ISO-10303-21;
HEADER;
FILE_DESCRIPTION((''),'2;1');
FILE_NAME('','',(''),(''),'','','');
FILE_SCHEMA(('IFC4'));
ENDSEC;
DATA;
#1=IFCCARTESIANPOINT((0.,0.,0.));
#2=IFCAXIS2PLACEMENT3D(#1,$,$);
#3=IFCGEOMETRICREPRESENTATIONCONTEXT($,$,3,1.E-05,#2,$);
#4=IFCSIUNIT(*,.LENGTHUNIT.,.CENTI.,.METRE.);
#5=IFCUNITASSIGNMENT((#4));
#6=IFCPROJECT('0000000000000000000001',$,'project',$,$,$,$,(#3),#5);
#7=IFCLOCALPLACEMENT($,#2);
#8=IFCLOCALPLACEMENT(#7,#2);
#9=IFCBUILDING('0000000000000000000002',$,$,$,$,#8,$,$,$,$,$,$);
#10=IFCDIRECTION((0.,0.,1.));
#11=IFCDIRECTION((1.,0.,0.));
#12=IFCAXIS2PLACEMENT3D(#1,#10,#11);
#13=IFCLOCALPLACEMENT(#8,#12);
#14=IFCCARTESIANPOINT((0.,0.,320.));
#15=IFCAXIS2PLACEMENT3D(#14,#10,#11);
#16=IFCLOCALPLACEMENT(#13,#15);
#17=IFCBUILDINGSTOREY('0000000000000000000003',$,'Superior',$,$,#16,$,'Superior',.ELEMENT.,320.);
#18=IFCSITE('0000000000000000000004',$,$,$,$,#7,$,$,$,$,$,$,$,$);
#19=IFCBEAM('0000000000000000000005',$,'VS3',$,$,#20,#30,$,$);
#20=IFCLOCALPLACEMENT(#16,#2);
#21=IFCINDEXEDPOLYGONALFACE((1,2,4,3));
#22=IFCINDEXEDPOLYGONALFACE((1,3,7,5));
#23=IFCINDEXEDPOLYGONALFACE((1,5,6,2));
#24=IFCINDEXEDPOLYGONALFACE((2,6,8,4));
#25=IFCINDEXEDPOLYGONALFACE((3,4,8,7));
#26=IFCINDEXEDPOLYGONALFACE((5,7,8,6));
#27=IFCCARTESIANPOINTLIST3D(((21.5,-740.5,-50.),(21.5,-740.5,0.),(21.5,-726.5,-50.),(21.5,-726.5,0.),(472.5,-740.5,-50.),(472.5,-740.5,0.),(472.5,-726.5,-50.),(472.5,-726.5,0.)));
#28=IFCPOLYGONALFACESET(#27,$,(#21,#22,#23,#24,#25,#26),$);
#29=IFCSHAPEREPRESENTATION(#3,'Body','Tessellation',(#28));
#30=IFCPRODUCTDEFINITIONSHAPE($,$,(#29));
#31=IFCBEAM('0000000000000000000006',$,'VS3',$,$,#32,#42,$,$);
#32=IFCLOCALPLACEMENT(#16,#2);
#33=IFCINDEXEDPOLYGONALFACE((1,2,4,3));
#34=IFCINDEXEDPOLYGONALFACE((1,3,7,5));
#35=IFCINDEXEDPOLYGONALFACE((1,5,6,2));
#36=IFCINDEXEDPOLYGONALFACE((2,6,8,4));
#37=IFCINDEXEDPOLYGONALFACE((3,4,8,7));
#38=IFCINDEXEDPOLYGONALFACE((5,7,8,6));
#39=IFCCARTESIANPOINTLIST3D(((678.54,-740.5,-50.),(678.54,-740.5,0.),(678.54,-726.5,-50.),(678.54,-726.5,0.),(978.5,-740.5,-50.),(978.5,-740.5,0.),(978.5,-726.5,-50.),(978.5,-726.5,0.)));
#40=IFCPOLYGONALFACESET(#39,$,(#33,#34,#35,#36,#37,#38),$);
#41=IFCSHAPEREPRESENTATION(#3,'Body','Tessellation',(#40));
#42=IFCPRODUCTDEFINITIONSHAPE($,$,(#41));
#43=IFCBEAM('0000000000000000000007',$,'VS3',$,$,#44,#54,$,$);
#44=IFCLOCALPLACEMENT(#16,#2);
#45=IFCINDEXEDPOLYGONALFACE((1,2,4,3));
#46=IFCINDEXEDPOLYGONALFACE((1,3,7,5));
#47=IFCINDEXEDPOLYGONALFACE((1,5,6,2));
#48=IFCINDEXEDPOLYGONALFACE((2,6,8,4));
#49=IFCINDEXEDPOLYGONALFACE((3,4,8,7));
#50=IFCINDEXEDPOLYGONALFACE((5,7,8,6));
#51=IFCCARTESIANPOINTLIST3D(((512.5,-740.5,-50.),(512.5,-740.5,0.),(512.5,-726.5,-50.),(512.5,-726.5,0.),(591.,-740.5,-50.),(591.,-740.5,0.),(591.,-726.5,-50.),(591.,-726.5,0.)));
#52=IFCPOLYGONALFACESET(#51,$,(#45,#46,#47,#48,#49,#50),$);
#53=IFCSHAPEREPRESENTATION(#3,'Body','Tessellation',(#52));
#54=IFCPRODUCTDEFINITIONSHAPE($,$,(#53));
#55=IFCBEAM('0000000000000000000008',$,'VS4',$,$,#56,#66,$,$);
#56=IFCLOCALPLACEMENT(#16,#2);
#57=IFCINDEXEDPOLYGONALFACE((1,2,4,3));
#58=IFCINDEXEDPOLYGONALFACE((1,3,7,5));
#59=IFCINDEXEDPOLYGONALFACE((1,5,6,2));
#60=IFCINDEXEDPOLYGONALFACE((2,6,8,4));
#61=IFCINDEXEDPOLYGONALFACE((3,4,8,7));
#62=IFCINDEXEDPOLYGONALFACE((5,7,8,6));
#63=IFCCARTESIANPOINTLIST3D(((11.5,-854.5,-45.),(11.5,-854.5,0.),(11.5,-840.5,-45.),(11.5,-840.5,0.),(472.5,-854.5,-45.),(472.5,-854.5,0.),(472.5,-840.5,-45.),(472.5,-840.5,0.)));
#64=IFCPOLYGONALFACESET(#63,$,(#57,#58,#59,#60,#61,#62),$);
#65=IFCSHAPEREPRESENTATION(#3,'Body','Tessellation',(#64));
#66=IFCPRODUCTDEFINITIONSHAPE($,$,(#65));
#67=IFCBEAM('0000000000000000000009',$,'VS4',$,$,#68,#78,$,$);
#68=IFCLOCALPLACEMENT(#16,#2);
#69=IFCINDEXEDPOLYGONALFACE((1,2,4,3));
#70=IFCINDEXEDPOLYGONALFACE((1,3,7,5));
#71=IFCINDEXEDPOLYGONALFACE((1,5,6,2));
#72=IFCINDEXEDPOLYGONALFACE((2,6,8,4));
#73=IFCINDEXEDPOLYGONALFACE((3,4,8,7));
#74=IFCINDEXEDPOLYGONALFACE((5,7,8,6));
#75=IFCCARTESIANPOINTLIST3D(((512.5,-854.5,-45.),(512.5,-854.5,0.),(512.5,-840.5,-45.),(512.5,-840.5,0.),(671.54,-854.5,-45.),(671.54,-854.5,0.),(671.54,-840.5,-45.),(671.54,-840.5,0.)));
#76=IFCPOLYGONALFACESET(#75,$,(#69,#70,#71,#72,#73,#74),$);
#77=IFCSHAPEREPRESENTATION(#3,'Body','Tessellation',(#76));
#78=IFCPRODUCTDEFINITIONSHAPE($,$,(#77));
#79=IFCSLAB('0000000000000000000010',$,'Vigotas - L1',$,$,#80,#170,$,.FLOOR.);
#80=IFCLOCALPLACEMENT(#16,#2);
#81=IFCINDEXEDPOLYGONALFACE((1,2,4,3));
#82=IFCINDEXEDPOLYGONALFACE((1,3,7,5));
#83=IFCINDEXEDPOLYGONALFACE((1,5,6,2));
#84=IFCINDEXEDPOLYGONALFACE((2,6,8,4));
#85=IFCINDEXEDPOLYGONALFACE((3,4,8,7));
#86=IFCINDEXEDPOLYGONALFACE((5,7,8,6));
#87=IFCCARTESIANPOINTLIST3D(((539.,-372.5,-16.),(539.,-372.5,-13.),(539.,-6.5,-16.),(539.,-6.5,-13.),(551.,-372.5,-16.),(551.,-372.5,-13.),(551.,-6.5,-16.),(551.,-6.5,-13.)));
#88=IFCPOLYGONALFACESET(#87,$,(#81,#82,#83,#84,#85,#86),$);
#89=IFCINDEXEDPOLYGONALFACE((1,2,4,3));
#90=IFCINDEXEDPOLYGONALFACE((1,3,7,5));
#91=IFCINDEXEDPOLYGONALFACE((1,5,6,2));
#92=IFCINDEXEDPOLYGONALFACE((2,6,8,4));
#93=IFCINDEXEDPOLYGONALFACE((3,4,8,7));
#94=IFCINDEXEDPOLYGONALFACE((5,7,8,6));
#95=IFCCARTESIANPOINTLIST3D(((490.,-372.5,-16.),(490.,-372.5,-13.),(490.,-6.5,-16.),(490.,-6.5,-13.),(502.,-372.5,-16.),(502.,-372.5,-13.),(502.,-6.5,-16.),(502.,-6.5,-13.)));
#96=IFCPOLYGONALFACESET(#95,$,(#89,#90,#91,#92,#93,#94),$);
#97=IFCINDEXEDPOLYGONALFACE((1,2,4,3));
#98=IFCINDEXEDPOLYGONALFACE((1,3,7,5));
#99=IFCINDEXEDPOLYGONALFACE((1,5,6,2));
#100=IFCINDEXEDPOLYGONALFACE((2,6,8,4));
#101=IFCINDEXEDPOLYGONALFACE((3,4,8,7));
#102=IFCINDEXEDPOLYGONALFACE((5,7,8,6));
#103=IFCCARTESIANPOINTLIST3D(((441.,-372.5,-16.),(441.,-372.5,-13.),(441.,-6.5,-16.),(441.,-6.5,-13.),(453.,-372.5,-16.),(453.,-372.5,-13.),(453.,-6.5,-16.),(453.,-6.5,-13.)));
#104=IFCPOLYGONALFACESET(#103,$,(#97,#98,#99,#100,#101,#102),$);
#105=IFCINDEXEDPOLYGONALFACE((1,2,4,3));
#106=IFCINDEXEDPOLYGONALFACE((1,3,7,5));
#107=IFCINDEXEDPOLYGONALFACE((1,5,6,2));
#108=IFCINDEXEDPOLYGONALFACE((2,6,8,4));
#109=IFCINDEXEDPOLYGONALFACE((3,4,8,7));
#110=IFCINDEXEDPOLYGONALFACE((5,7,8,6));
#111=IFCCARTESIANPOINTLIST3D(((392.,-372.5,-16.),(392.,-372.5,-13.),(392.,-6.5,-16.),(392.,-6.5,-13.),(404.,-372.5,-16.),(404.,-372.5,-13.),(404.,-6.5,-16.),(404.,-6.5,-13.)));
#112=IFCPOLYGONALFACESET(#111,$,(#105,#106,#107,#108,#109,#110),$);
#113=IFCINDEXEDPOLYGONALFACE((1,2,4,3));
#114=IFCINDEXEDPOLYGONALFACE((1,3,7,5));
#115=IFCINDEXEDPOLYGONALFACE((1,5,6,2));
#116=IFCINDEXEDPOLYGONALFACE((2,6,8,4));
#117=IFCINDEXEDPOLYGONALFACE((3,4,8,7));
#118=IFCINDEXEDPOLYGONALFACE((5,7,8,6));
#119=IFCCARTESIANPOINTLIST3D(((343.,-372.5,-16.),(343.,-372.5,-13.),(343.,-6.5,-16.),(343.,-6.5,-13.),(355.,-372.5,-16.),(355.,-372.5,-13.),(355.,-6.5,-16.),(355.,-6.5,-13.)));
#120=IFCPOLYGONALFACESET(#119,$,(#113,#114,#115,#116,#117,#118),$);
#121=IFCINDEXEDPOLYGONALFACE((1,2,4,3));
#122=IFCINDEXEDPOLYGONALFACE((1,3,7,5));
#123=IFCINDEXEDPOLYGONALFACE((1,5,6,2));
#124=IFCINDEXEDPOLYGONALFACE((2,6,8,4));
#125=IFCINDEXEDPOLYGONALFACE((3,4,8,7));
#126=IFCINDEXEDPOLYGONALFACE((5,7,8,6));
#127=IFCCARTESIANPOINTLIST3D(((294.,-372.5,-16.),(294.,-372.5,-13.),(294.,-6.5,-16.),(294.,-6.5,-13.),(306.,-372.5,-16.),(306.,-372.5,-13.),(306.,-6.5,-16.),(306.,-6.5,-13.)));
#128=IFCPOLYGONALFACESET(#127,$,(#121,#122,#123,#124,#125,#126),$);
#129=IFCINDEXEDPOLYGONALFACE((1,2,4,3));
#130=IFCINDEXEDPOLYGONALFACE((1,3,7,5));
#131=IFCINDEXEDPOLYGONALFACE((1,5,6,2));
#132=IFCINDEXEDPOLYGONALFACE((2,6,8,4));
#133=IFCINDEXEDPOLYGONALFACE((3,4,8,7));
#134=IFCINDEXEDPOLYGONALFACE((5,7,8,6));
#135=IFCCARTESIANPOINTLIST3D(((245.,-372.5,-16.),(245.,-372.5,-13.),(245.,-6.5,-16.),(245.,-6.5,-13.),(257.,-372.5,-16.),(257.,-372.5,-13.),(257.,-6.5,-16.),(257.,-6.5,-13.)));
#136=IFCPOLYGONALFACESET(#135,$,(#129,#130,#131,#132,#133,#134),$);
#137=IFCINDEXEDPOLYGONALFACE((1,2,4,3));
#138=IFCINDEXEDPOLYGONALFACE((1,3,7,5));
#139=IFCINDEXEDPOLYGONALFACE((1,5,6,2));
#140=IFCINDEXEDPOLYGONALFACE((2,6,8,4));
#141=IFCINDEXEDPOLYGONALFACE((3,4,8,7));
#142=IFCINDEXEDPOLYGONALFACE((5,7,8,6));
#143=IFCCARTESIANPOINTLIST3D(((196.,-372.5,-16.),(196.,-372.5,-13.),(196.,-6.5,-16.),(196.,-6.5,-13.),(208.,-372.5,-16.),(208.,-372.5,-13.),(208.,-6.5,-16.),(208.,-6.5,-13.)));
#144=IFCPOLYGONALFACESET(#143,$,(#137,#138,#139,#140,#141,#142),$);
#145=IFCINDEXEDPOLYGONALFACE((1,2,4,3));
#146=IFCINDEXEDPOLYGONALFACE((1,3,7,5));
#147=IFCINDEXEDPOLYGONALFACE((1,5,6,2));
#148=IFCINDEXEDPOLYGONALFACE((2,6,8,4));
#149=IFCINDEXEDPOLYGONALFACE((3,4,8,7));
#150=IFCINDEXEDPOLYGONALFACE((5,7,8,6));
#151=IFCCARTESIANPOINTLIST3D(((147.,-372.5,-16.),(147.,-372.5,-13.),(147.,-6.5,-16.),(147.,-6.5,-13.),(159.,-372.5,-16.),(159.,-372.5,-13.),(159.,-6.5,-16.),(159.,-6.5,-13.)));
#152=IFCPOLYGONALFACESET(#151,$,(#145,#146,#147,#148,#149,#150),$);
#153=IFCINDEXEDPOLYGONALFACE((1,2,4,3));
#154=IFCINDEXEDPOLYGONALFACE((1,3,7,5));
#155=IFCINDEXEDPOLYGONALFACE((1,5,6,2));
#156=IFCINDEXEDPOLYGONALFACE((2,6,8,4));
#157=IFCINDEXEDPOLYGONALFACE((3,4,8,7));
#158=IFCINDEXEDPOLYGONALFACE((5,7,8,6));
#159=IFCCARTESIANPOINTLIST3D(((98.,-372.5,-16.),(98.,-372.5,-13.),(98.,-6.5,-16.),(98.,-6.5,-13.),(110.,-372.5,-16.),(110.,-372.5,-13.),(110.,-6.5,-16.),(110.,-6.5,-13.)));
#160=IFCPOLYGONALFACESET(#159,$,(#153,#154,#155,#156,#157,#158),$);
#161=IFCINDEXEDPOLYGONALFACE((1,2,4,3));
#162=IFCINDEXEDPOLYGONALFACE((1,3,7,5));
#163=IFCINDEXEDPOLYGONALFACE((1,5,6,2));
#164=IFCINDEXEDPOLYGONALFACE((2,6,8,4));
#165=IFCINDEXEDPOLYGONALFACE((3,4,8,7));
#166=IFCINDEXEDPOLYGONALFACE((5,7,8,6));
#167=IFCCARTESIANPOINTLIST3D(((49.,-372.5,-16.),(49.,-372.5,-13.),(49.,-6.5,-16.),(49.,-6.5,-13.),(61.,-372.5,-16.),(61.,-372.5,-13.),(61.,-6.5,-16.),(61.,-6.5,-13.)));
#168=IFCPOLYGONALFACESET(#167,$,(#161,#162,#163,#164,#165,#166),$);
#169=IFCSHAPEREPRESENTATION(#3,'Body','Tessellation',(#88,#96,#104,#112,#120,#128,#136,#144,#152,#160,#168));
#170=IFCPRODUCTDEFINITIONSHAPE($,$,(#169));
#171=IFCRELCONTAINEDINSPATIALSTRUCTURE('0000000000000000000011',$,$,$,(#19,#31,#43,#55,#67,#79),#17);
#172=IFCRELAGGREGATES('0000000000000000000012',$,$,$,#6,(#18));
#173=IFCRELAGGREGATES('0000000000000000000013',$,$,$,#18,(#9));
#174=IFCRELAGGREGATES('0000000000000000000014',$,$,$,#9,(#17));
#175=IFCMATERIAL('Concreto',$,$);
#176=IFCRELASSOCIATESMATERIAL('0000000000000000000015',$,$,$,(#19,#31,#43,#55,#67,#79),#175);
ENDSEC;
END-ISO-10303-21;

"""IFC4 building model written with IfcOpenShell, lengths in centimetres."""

from ifc_helpers import new_model, si_unit, frame, origin, origin_with_axes, place, context, project, spatial, polyline, outline, extrude, material, element, save


model = new_model("IFC4")

# Units and contexts
context_of_model = context(None, 3, precision=1e-05, world=origin())
ifc_project = project(units=[si_unit("LENGTHUNIT", "METRE", prefix="CENTI")], contexts=[context_of_model])

# Site, building, storey
site_placement = place(None, origin())
site = spatial("IfcSite", under=ifc_project, at=site_placement)
building_placement = place(site_placement, origin())
building = spatial("IfcBuilding", under=site, at=building_placement)
placement = place(building_placement, origin_with_axes())
storey_placement = place(placement, frame((0.0, 0.0, 320.0), z_axis=(0.0, 0.0, 1.0), x_axis=(1.0, 0.0, 0.0)))
storey = spatial("IfcBuildingStorey", under=building, at=storey_placement, Name="Superior", LongName="Superior", CompositionType="ELEMENT", Elevation=320.0)

# Shared definitions
ifc_material = material(Name="Concreto")

# Beams
beam_1_placement = place(storey_placement, frame((247.0, -733.5, 0.0), z_axis=(0.0, 0.0, 1.0), x_axis=(1.0, 0.0, 0.0)))
element("IfcBeam", 1, at=beam_1_placement, inside=storey, material=ifc_material, Name="VS3", context=context_of_model, shape_type="SolidModel", body=[
    extrude(outline(polyline([(-7.0, -25.0), (7.0, -25.0), (7.0, 25.0), (-7.0, 25.0), (-7.0, -25.0)])), frame((-225.5, 0.0, -25.0), z_axis=(1.0, 0.0, 0.0), x_axis=(0.0, -1.0, 0.0)), (0.0, 0.0, 1.0), 451.0),
])
beam_2_placement = place(storey_placement, frame((828.52, -733.5, 0.0), z_axis=(0.0, 0.0, 1.0), x_axis=(1.0, 0.0, 0.0)))
element("IfcBeam", 2, at=beam_2_placement, inside=storey, material=ifc_material, Name="VS3", context=context_of_model, shape_type="SolidModel", body=[
    extrude(outline(polyline([(-7.0, -25.0), (7.0, -25.0), (7.0, 25.0), (-7.0, 25.0), (-7.0, -25.0)])), frame((-149.98, 0.0, -25.0), z_axis=(1.0, 0.0, 0.0), x_axis=(0.0, -1.0, 0.0)), (0.0, 0.0, 1.0), 299.96),
])
beam_3_placement = place(storey_placement, frame((551.75, -733.5, 0.0), z_axis=(0.0, 0.0, 1.0), x_axis=(1.0, 0.0, 0.0)))
element("IfcBeam", 3, at=beam_3_placement, inside=storey, material=ifc_material, Name="VS3", context=context_of_model, shape_type="SolidModel", body=[
    extrude(outline(polyline([(-7.0, -25.0), (7.0, -25.0), (7.0, 25.0), (-7.0, 25.0), (-7.0, -25.0)])), frame((-39.25, 0.0, -25.0), z_axis=(1.0, 0.0, 0.0), x_axis=(0.0, -1.0, 0.0)), (0.0, 0.0, 1.0), 78.5),
])
beam_4_placement = place(storey_placement, frame((242.0, -847.5, 0.0), z_axis=(0.0, 0.0, 1.0), x_axis=(1.0, 0.0, 0.0)))
element("IfcBeam", 4, at=beam_4_placement, inside=storey, material=ifc_material, Name="VS4", context=context_of_model, shape_type="SolidModel", body=[
    extrude(outline(polyline([(-7.0, -22.5), (7.0, -22.5), (7.0, 22.5), (-7.0, 22.5), (-7.0, -22.5)])), frame((-230.5, 0.0, -22.5), z_axis=(1.0, 0.0, 0.0), x_axis=(0.0, -1.0, 0.0)), (0.0, 0.0, 1.0), 461.0),
])
beam_5_placement = place(storey_placement, frame((592.02, -847.5, 0.0), z_axis=(0.0, 0.0, 1.0), x_axis=(1.0, 0.0, 0.0)))
element("IfcBeam", 5, at=beam_5_placement, inside=storey, material=ifc_material, Name="VS4", context=context_of_model, shape_type="SolidModel", body=[
    extrude(outline(polyline([(-7.0, -22.5), (7.0, -22.5), (7.0, 22.5), (-7.0, 22.5), (-7.0, -22.5)])), frame((-79.52, 0.0, -22.5), z_axis=(1.0, 0.0, 0.0), x_axis=(0.0, -1.0, 0.0)), (0.0, 0.0, 1.0), 159.04),
])

# Slab
slab_1_placement = place(storey_placement, frame((300.0, -189.5, -13.0), z_axis=(0.0, 0.0, 1.0), x_axis=(1.0, 0.0, 0.0)))
element("IfcSlab", 6, at=slab_1_placement, inside=storey, material=ifc_material, Name="Vigotas - L1", PredefinedType="FLOOR", context=context_of_model, shape_type="SolidModel", body=[
    extrude(outline(polyline([(6.0, 1.5), (-6.0, 1.5), (-6.0, -1.5), (6.0, -1.5), (6.0, 1.5), (6.0, 1.5)])), frame((245.0, -183.0, -1.5), z_axis=(0.0, 1.0, 0.0), x_axis=(1.0, 0.0, 0.0)), (0.0, 0.0, 1.0), 366.0),
    extrude(outline(polyline([(6.0, 1.5), (-6.0, 1.5), (-6.0, -1.5), (6.0, -1.5), (6.0, 1.5), (6.0, 1.5)])), frame((196.0, -183.0, -1.5), z_axis=(0.0, 1.0, 0.0), x_axis=(1.0, 0.0, 0.0)), (0.0, 0.0, 1.0), 366.0),
    extrude(outline(polyline([(6.0, 1.5), (-6.0, 1.5), (-6.0, -1.5), (6.0, -1.5), (6.0, 1.5), (6.0, 1.5)])), frame((147.0, -183.0, -1.5), z_axis=(0.0, 1.0, 0.0), x_axis=(1.0, 0.0, 0.0)), (0.0, 0.0, 1.0), 366.0),
    extrude(outline(polyline([(6.0, 1.5), (-6.0, 1.5), (-6.0, -1.5), (6.0, -1.5), (6.0, 1.5), (6.0, 1.5)])), frame((98.0, -183.0, -1.5), z_axis=(0.0, 1.0, 0.0), x_axis=(1.0, 0.0, 0.0)), (0.0, 0.0, 1.0), 366.0),
    extrude(outline(polyline([(6.0, 1.5), (-6.0, 1.5), (-6.0, -1.5), (6.0, -1.5), (6.0, 1.5), (6.0, 1.5)])), frame((49.0, -183.0, -1.5), z_axis=(0.0, 1.0, 0.0), x_axis=(1.0, 0.0, 0.0)), (0.0, 0.0, 1.0), 366.0),
    extrude(outline(polyline([(6.0, 1.5), (-6.0, 1.5), (-6.0, -1.5), (6.0, -1.5), (6.0, 1.5), (6.0, 1.5)])), frame((0.0, -183.0, -1.5), z_axis=(0.0, 1.0, 0.0), x_axis=(1.0, 0.0, 0.0)), (0.0, 0.0, 1.0), 366.0),
    extrude(outline(polyline([(6.0, 1.5), (-6.0, 1.5), (-6.0, -1.5), (6.0, -1.5), (6.0, 1.5), (6.0, 1.5)])), frame((-49.0, -183.0, -1.5), z_axis=(0.0, 1.0, 0.0), x_axis=(1.0, 0.0, 0.0)), (0.0, 0.0, 1.0), 366.0),
    extrude(outline(polyline([(6.0, 1.5), (-6.0, 1.5), (-6.0, -1.5), (6.0, -1.5), (6.0, 1.5), (6.0, 1.5)])), frame((-98.0, -183.0, -1.5), z_axis=(0.0, 1.0, 0.0), x_axis=(1.0, 0.0, 0.0)), (0.0, 0.0, 1.0), 366.0),
    extrude(outline(polyline([(6.0, 1.5), (-6.0, 1.5), (-6.0, -1.5), (6.0, -1.5), (6.0, 1.5), (6.0, 1.5)])), frame((-147.0, -183.0, -1.5), z_axis=(0.0, 1.0, 0.0), x_axis=(1.0, 0.0, 0.0)), (0.0, 0.0, 1.0), 366.0),
    extrude(outline(polyline([(6.0, 1.5), (-6.0, 1.5), (-6.0, -1.5), (6.0, -1.5), (6.0, 1.5), (6.0, 1.5)])), frame((-196.0, -183.0, -1.5), z_axis=(0.0, 1.0, 0.0), x_axis=(1.0, 0.0, 0.0)), (0.0, 0.0, 1.0), 366.0),
    extrude(outline(polyline([(6.0, 1.5), (-6.0, 1.5), (-6.0, -1.5), (6.0, -1.5), (6.0, 1.5), (6.0, 1.5)])), frame((-245.0, -183.0, -1.5), z_axis=(0.0, 1.0, 0.0), x_axis=(1.0, 0.0, 0.0)), (0.0, 0.0, 1.0), 366.0),
])

save(model, "model.ifc")
